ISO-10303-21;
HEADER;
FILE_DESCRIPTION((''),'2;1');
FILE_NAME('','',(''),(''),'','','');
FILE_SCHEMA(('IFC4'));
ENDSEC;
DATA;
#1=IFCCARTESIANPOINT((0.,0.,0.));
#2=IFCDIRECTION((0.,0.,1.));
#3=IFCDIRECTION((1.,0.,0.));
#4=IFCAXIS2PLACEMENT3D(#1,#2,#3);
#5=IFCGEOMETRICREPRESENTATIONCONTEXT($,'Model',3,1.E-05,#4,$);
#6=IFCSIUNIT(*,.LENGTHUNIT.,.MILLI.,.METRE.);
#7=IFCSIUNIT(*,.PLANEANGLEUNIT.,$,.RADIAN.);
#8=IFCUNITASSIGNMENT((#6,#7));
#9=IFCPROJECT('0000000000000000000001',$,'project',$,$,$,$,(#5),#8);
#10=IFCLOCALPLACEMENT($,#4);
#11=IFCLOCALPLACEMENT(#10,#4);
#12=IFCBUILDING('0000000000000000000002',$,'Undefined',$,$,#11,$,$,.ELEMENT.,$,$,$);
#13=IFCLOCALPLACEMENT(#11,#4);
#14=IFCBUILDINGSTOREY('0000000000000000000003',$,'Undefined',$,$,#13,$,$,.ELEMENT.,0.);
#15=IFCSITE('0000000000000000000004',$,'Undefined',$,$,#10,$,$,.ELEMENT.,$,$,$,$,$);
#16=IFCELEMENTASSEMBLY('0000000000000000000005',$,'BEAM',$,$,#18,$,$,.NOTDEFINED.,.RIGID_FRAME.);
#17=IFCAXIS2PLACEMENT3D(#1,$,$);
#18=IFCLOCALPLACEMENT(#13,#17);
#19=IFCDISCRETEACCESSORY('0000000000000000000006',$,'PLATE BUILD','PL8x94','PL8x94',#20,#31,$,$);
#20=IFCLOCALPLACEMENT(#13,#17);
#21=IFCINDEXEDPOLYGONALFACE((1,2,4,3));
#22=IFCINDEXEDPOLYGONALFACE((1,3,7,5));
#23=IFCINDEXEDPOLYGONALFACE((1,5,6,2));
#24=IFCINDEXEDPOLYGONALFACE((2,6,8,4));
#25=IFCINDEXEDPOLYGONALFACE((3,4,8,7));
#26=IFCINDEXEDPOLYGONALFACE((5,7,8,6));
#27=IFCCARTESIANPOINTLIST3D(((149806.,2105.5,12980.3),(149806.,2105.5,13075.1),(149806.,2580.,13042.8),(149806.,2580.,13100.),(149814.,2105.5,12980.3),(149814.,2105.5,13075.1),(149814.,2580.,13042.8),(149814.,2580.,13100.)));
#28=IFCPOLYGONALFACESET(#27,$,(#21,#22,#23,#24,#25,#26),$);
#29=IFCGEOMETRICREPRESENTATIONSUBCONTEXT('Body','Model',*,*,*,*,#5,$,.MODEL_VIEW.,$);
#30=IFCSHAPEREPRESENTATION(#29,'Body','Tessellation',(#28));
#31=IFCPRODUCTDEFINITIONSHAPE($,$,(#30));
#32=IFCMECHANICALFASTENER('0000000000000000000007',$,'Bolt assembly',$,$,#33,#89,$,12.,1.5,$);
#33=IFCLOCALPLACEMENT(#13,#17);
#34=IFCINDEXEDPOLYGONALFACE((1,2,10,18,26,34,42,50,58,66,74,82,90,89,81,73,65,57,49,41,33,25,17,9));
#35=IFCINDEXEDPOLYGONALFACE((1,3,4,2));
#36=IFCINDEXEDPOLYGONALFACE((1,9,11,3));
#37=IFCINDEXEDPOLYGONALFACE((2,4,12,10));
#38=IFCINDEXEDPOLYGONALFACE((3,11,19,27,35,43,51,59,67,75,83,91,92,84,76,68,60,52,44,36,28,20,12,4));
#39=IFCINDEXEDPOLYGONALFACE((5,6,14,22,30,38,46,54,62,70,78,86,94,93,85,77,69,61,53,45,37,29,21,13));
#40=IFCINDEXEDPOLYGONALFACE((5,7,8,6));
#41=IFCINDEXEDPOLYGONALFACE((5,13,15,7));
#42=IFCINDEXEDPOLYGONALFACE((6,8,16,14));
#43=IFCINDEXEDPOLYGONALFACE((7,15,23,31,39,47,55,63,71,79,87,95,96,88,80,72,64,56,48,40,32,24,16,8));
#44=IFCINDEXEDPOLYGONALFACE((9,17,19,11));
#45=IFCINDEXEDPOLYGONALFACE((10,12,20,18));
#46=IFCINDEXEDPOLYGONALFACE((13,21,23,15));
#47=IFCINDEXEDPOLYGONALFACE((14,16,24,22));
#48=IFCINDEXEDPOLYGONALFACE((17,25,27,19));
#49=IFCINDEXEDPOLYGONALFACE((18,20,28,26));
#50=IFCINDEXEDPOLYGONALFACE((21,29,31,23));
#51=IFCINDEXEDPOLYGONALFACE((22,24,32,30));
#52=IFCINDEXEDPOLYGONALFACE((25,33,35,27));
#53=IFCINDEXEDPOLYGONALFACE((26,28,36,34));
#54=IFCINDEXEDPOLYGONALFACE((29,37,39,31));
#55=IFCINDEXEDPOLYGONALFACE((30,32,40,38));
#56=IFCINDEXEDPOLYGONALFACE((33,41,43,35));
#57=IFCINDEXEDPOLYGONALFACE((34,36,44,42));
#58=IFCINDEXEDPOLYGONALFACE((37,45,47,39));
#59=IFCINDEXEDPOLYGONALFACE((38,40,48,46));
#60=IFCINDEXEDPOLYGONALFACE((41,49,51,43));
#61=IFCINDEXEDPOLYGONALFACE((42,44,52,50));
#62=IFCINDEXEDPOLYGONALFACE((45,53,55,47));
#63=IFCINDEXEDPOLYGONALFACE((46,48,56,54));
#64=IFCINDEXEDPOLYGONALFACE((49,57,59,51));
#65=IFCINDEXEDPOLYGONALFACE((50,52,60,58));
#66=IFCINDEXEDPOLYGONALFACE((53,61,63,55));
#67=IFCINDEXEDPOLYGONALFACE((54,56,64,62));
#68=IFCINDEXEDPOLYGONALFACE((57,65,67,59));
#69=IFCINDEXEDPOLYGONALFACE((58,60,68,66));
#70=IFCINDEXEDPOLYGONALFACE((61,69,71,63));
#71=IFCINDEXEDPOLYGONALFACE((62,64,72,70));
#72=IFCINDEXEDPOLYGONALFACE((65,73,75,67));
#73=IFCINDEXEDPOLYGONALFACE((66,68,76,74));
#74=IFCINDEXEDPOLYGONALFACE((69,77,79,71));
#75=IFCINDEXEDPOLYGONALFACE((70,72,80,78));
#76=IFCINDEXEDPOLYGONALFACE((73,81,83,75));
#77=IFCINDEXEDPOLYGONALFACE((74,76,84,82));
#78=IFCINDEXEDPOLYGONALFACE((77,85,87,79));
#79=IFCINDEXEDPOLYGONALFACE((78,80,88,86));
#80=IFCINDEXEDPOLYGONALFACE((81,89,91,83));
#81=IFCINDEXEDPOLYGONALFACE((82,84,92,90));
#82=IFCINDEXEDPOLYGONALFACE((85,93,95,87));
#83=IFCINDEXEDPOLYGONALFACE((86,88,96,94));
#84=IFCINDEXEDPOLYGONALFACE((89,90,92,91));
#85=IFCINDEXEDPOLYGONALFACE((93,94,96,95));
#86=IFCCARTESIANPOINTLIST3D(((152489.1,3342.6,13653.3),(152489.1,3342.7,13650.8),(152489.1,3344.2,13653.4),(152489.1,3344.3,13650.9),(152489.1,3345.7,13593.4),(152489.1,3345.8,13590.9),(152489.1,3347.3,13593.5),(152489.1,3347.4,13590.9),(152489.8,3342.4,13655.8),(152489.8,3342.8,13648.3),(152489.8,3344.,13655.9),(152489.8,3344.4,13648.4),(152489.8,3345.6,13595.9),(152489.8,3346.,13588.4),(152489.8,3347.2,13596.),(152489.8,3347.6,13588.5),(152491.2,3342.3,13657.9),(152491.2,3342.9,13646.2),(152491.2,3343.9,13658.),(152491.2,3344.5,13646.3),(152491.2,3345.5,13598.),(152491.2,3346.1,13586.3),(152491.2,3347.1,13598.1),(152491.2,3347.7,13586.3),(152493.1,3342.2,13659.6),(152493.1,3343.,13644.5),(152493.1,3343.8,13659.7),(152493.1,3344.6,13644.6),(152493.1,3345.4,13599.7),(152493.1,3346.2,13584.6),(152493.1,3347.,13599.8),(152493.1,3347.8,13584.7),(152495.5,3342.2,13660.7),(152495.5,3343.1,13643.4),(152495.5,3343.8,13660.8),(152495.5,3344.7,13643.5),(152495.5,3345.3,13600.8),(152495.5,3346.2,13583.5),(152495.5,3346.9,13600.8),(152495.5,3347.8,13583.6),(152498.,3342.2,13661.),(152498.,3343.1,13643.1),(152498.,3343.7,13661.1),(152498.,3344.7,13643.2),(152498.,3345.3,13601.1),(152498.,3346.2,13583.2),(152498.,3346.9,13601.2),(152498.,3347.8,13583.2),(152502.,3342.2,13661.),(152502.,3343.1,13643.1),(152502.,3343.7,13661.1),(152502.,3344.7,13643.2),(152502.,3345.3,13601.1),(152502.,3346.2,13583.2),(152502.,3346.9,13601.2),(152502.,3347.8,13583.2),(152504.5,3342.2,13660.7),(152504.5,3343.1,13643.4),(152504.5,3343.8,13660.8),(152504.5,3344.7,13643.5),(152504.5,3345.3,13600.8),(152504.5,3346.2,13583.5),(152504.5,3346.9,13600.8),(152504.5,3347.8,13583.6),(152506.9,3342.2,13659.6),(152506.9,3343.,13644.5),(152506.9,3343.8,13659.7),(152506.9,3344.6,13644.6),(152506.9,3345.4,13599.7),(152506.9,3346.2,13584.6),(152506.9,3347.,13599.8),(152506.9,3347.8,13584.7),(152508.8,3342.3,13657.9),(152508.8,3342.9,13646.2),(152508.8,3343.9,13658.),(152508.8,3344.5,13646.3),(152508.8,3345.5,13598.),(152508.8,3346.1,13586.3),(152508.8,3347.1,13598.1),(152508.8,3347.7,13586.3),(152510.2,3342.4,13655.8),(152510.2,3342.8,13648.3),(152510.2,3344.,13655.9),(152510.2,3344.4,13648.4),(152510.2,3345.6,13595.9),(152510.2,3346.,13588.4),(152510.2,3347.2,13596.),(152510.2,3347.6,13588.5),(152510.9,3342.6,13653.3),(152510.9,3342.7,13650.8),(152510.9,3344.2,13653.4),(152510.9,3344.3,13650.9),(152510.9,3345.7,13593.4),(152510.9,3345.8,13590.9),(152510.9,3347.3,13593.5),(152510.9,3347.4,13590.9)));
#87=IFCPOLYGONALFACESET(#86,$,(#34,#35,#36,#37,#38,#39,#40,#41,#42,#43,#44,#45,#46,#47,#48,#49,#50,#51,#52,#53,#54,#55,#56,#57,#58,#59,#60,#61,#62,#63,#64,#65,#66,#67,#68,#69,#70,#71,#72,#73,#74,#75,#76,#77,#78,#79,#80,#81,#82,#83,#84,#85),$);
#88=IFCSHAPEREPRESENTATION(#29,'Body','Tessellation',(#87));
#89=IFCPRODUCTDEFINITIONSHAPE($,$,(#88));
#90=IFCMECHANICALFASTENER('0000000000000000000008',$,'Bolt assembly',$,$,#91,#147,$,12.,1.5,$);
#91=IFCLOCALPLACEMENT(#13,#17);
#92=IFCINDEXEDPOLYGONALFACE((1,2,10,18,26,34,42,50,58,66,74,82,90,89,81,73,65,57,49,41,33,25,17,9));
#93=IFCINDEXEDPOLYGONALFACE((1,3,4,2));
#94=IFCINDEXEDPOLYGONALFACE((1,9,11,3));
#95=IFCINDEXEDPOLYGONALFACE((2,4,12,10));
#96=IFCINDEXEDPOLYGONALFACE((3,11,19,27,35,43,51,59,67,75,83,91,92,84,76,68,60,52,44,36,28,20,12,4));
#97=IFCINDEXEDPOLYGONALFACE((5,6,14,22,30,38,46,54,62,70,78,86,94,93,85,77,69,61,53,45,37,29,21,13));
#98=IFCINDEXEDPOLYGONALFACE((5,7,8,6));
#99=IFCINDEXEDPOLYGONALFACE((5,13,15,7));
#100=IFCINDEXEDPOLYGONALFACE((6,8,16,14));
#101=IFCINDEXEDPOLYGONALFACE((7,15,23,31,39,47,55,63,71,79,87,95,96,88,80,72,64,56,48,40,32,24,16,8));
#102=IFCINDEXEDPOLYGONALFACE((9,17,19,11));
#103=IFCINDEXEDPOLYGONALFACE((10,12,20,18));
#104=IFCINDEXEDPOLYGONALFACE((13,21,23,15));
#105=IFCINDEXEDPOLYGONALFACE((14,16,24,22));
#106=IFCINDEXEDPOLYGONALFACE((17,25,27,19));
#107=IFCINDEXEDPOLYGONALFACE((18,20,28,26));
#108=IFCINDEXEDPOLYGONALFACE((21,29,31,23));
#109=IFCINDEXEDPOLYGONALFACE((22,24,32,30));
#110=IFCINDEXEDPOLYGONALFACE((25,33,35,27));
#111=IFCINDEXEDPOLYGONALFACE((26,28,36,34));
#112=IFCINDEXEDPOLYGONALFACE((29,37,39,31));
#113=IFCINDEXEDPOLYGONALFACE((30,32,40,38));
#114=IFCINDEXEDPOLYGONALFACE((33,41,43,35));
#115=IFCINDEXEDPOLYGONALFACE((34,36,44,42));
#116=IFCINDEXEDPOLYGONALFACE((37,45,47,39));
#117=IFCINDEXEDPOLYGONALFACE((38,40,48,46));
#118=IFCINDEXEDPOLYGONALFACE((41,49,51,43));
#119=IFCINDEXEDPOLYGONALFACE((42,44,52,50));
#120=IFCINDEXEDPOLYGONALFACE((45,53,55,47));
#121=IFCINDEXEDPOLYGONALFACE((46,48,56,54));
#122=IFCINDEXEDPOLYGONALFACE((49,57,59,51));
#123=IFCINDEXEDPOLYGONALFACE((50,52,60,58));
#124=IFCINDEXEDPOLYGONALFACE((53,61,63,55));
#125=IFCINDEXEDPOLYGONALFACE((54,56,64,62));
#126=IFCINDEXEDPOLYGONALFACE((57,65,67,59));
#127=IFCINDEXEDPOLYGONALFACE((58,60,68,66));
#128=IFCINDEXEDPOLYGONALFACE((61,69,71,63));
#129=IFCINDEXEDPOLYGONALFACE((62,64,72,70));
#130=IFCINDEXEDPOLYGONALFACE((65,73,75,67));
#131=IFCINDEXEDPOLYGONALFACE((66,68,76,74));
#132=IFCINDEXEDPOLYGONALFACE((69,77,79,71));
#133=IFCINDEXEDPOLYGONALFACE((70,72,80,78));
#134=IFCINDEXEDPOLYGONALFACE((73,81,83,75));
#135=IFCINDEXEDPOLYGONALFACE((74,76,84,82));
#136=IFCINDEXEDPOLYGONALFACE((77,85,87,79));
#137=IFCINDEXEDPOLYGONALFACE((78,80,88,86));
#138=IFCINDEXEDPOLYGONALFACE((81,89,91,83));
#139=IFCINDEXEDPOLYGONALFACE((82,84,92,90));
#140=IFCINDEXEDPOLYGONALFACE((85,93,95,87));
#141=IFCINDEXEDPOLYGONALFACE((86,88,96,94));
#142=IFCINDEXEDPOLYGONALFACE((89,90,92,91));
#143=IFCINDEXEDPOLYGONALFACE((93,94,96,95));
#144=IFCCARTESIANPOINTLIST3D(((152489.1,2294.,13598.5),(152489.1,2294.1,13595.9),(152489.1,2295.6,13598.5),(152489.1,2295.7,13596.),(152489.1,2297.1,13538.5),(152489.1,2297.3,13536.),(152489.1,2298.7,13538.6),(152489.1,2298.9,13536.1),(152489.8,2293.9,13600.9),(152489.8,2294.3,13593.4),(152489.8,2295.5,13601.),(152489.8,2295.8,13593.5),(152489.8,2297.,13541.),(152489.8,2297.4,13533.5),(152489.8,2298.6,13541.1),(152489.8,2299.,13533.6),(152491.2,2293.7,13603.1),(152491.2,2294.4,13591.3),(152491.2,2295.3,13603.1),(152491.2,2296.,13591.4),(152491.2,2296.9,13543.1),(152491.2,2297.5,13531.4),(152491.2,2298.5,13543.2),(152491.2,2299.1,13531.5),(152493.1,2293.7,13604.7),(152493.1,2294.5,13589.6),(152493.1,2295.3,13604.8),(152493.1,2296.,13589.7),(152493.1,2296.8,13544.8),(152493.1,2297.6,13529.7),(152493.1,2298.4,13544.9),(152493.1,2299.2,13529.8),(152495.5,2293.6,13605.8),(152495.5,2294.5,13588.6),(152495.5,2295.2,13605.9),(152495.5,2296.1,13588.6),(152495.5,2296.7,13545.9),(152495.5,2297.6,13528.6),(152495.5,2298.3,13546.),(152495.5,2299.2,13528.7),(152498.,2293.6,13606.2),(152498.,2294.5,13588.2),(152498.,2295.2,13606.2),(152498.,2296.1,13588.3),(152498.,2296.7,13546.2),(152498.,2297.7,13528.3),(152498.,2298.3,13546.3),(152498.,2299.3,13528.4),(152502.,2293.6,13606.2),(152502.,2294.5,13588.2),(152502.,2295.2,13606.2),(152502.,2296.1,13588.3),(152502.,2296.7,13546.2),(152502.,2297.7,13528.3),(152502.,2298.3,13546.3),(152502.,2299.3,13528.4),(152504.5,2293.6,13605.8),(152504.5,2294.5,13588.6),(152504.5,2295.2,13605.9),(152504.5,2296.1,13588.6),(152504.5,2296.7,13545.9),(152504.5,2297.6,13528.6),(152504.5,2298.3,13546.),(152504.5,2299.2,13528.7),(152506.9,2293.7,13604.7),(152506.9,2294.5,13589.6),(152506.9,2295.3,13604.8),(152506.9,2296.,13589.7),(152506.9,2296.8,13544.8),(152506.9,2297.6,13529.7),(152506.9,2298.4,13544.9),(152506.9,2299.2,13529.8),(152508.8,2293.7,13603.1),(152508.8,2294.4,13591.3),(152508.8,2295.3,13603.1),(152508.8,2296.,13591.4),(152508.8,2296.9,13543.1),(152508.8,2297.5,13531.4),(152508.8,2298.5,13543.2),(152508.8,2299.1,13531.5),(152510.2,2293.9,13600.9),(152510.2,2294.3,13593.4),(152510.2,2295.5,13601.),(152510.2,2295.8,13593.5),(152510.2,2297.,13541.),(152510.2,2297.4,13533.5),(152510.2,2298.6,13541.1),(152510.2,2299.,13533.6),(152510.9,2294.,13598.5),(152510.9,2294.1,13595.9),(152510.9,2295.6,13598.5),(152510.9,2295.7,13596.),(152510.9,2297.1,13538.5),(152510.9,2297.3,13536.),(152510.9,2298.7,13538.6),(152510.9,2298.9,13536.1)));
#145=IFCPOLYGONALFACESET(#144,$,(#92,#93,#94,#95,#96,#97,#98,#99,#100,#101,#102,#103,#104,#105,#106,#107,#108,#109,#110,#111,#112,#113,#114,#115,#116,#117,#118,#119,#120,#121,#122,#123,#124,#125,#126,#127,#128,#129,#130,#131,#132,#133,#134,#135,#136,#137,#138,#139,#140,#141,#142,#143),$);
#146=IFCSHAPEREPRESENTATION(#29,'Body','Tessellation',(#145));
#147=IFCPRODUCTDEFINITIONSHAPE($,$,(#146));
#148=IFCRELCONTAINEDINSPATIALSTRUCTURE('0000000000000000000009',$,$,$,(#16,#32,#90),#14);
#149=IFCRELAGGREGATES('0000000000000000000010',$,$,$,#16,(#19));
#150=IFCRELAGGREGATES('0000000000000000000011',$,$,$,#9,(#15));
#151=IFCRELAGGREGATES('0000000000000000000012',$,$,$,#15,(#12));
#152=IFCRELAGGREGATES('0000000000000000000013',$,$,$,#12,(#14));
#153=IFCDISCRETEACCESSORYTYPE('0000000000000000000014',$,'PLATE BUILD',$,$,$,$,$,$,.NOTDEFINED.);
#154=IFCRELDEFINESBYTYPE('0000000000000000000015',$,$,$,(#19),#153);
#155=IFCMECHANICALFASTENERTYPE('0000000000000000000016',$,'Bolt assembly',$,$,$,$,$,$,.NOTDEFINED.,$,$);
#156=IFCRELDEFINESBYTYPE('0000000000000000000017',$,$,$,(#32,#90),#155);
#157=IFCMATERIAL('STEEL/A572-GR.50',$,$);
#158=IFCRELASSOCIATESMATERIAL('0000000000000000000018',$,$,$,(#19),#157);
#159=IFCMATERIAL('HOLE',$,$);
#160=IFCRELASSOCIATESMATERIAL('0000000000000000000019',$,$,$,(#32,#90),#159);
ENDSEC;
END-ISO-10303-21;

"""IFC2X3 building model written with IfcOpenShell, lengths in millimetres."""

from ifc_helpers import new_model, si_unit, frame, frame_2d, origin_with_axes, place, context, subcontext, project, spatial, polyline, circle_curve, parameter, trimmed, segment, composite_curve, outline, extrude, source, transform, mapped, material, type_object, element, aggregate, save


model = new_model("IFC2X3")

# Units and contexts
model_context = context("Model", 3, precision=1e-05, world=origin_with_axes())
body_context = subcontext(model_context, "Body", "Model", "MODEL_VIEW")
ifc_project = project(units=[si_unit("LENGTHUNIT", "METRE", prefix="MILLI"), si_unit("PLANEANGLEUNIT", "RADIAN")], contexts=[model_context])

# Site, building, storey
site_placement = place(None, origin_with_axes())
site = spatial("IfcSite", under=ifc_project, at=site_placement, Name="Undefined", CompositionType="ELEMENT")
building_placement = place(site_placement, origin_with_axes())
building = spatial("IfcBuilding", under=site, at=building_placement, Name="Undefined", CompositionType="ELEMENT")
storey_placement = place(building_placement, origin_with_axes())
storey = spatial("IfcBuildingStorey", under=building, at=storey_placement, Name="Undefined", CompositionType="ELEMENT", Elevation=0.0)

# Shared definitions
ifc_material_1 = material(Name="STEEL/A572-GR.50")

# Element assembly
assembly_1_placement = place(storey_placement, origin_with_axes())
assembly_1 = element("IfcElementAssembly", 1, at=assembly_1_placement, inside=storey, Name="BEAM", AssemblyPlace="NOTDEFINED", PredefinedType="RIGID_FRAME")

# Discrete accessory
discrete_accessory_type_1 = type_object("IfcDiscreteAccessoryType", Name="PLATE BUILD")
discrete_accessory_1_placement = place(assembly_1_placement, frame((149810.0, 2580.0, 13042.8), z_axis=(1.0, 0.0, 0.0), x_axis=(0.0, -0.000009, 1.0)))
discrete_accessory_1 = element("IfcDiscreteAccessory", 2, at=discrete_accessory_1_placement, type_object=discrete_accessory_type_1, material=ifc_material_1, Name="PLATE BUILD", Description="PL8x94", ObjectType="PL8x94", context=body_context, shape_type="SweptSolid", body=[
    extrude(outline(polyline([(0.0, 0.0), (57.2, 0.0), (32.3, 474.5), (-62.5, 474.5), (0.0, 0.0)])), frame((0.0, 0.0, -4.0), z_axis=(0.0, 0.0, 1.0), x_axis=(1.0, 0.0, 0.0)), (0.0, 0.0, 1.0), 8.0),
])
aggregate(assembly_1, [discrete_accessory_1])

# Mechanical fasteners
ifc_material_2 = material(Name="HOLE")
mechanical_fastener_type = type_object("IfcMechanicalFastenerType", Name="Bolt assembly")
shared_shape_1 = source(origin_with_axes(), body_context, "Body", "SweptSolid", [
    extrude(outline(composite_curve([segment(polyline([(9.0, 2.0), (9.0, -2.0)]), True, "CONTINUOUS"), segment(trimmed(circle_curve(frame_2d((0.0, -2.0), x_axis=(1.0, 0.0)), 9.0), [parameter(0.0)], [parameter(3.141593)], False, "PARAMETER"), True, "CONTINUOUS"), segment(polyline([(-9.0, -2.0), (-9.0, 2.0)]), True, "CONTINUOUS"), segment(trimmed(circle_curve(frame_2d((0.0, 2.0), x_axis=(-1.0, 0.0)), 9.0), [parameter(0.0)], [parameter(3.141593)], False, "PARAMETER"), True, "DISCONTINUOUS")], self_intersect=False)), frame((0.0, 0.0, 0.0), z_axis=(0.0, 1.0, 0.0), x_axis=(1.0, 0.0, 0.0)), (0.0, 0.0, 1.0), 1.6),
])
mechanical_fastener_1_placement = place(storey_placement, frame((152500.0, 3347.4, 13592.2), z_axis=(1.0, 0.0, 0.0), x_axis=(0.0, -0.052361, 0.998628)))
element("IfcMechanicalFastener", 3, at=mechanical_fastener_1_placement, inside=storey, type_object=mechanical_fastener_type, material=ifc_material_2, Name="Bolt assembly", NominalDiameter=12.0, NominalLength=1.5, context=body_context, shape_type="MappedRepresentation", body=[
    mapped(shared_shape_1, transform((0.0, 0.0, 0.0))),
    mapped(shared_shape_1, transform((60.0, 0.0, 0.0))),
])
shared_shape_2 = source(origin_with_axes(), body_context, "Body", "SweptSolid", [
    extrude(outline(composite_curve([segment(polyline([(9.0, 2.0), (9.0, -2.0)]), True, "CONTINUOUS"), segment(trimmed(circle_curve(frame_2d((0.0, -2.0), x_axis=(1.0, 0.0)), 9.0), [parameter(0.0)], [parameter(3.141593)], False, "PARAMETER"), True, "CONTINUOUS"), segment(polyline([(-9.0, -2.0), (-9.0, 2.0)]), True, "CONTINUOUS"), segment(trimmed(circle_curve(frame_2d((0.0, 2.0), x_axis=(-1.0, 0.0)), 9.0), [parameter(0.0)], [parameter(3.141593)], False, "PARAMETER"), True, "DISCONTINUOUS")], self_intersect=False)), frame((0.0, 0.0, 0.0), z_axis=(0.0, 1.0, 0.0), x_axis=(1.0, 0.0, 0.0)), (0.0, 0.0, 1.0), 1.6),
])
mechanical_fastener_2_placement = place(storey_placement, frame((152500.0, 2298.8, 13537.3), z_axis=(1.0, 0.0, 0.0), x_axis=(0.0, -0.052361, 0.998628)))
element("IfcMechanicalFastener", 4, at=mechanical_fastener_2_placement, inside=storey, type_object=mechanical_fastener_type, material=ifc_material_2, Name="Bolt assembly", NominalDiameter=12.0, NominalLength=1.5, context=body_context, shape_type="MappedRepresentation", body=[
    mapped(shared_shape_2, transform((0.0, 0.0, 0.0))),
    mapped(shared_shape_2, transform((60.0, 0.0, 0.0))),
])

save(model, "model.ifc")
